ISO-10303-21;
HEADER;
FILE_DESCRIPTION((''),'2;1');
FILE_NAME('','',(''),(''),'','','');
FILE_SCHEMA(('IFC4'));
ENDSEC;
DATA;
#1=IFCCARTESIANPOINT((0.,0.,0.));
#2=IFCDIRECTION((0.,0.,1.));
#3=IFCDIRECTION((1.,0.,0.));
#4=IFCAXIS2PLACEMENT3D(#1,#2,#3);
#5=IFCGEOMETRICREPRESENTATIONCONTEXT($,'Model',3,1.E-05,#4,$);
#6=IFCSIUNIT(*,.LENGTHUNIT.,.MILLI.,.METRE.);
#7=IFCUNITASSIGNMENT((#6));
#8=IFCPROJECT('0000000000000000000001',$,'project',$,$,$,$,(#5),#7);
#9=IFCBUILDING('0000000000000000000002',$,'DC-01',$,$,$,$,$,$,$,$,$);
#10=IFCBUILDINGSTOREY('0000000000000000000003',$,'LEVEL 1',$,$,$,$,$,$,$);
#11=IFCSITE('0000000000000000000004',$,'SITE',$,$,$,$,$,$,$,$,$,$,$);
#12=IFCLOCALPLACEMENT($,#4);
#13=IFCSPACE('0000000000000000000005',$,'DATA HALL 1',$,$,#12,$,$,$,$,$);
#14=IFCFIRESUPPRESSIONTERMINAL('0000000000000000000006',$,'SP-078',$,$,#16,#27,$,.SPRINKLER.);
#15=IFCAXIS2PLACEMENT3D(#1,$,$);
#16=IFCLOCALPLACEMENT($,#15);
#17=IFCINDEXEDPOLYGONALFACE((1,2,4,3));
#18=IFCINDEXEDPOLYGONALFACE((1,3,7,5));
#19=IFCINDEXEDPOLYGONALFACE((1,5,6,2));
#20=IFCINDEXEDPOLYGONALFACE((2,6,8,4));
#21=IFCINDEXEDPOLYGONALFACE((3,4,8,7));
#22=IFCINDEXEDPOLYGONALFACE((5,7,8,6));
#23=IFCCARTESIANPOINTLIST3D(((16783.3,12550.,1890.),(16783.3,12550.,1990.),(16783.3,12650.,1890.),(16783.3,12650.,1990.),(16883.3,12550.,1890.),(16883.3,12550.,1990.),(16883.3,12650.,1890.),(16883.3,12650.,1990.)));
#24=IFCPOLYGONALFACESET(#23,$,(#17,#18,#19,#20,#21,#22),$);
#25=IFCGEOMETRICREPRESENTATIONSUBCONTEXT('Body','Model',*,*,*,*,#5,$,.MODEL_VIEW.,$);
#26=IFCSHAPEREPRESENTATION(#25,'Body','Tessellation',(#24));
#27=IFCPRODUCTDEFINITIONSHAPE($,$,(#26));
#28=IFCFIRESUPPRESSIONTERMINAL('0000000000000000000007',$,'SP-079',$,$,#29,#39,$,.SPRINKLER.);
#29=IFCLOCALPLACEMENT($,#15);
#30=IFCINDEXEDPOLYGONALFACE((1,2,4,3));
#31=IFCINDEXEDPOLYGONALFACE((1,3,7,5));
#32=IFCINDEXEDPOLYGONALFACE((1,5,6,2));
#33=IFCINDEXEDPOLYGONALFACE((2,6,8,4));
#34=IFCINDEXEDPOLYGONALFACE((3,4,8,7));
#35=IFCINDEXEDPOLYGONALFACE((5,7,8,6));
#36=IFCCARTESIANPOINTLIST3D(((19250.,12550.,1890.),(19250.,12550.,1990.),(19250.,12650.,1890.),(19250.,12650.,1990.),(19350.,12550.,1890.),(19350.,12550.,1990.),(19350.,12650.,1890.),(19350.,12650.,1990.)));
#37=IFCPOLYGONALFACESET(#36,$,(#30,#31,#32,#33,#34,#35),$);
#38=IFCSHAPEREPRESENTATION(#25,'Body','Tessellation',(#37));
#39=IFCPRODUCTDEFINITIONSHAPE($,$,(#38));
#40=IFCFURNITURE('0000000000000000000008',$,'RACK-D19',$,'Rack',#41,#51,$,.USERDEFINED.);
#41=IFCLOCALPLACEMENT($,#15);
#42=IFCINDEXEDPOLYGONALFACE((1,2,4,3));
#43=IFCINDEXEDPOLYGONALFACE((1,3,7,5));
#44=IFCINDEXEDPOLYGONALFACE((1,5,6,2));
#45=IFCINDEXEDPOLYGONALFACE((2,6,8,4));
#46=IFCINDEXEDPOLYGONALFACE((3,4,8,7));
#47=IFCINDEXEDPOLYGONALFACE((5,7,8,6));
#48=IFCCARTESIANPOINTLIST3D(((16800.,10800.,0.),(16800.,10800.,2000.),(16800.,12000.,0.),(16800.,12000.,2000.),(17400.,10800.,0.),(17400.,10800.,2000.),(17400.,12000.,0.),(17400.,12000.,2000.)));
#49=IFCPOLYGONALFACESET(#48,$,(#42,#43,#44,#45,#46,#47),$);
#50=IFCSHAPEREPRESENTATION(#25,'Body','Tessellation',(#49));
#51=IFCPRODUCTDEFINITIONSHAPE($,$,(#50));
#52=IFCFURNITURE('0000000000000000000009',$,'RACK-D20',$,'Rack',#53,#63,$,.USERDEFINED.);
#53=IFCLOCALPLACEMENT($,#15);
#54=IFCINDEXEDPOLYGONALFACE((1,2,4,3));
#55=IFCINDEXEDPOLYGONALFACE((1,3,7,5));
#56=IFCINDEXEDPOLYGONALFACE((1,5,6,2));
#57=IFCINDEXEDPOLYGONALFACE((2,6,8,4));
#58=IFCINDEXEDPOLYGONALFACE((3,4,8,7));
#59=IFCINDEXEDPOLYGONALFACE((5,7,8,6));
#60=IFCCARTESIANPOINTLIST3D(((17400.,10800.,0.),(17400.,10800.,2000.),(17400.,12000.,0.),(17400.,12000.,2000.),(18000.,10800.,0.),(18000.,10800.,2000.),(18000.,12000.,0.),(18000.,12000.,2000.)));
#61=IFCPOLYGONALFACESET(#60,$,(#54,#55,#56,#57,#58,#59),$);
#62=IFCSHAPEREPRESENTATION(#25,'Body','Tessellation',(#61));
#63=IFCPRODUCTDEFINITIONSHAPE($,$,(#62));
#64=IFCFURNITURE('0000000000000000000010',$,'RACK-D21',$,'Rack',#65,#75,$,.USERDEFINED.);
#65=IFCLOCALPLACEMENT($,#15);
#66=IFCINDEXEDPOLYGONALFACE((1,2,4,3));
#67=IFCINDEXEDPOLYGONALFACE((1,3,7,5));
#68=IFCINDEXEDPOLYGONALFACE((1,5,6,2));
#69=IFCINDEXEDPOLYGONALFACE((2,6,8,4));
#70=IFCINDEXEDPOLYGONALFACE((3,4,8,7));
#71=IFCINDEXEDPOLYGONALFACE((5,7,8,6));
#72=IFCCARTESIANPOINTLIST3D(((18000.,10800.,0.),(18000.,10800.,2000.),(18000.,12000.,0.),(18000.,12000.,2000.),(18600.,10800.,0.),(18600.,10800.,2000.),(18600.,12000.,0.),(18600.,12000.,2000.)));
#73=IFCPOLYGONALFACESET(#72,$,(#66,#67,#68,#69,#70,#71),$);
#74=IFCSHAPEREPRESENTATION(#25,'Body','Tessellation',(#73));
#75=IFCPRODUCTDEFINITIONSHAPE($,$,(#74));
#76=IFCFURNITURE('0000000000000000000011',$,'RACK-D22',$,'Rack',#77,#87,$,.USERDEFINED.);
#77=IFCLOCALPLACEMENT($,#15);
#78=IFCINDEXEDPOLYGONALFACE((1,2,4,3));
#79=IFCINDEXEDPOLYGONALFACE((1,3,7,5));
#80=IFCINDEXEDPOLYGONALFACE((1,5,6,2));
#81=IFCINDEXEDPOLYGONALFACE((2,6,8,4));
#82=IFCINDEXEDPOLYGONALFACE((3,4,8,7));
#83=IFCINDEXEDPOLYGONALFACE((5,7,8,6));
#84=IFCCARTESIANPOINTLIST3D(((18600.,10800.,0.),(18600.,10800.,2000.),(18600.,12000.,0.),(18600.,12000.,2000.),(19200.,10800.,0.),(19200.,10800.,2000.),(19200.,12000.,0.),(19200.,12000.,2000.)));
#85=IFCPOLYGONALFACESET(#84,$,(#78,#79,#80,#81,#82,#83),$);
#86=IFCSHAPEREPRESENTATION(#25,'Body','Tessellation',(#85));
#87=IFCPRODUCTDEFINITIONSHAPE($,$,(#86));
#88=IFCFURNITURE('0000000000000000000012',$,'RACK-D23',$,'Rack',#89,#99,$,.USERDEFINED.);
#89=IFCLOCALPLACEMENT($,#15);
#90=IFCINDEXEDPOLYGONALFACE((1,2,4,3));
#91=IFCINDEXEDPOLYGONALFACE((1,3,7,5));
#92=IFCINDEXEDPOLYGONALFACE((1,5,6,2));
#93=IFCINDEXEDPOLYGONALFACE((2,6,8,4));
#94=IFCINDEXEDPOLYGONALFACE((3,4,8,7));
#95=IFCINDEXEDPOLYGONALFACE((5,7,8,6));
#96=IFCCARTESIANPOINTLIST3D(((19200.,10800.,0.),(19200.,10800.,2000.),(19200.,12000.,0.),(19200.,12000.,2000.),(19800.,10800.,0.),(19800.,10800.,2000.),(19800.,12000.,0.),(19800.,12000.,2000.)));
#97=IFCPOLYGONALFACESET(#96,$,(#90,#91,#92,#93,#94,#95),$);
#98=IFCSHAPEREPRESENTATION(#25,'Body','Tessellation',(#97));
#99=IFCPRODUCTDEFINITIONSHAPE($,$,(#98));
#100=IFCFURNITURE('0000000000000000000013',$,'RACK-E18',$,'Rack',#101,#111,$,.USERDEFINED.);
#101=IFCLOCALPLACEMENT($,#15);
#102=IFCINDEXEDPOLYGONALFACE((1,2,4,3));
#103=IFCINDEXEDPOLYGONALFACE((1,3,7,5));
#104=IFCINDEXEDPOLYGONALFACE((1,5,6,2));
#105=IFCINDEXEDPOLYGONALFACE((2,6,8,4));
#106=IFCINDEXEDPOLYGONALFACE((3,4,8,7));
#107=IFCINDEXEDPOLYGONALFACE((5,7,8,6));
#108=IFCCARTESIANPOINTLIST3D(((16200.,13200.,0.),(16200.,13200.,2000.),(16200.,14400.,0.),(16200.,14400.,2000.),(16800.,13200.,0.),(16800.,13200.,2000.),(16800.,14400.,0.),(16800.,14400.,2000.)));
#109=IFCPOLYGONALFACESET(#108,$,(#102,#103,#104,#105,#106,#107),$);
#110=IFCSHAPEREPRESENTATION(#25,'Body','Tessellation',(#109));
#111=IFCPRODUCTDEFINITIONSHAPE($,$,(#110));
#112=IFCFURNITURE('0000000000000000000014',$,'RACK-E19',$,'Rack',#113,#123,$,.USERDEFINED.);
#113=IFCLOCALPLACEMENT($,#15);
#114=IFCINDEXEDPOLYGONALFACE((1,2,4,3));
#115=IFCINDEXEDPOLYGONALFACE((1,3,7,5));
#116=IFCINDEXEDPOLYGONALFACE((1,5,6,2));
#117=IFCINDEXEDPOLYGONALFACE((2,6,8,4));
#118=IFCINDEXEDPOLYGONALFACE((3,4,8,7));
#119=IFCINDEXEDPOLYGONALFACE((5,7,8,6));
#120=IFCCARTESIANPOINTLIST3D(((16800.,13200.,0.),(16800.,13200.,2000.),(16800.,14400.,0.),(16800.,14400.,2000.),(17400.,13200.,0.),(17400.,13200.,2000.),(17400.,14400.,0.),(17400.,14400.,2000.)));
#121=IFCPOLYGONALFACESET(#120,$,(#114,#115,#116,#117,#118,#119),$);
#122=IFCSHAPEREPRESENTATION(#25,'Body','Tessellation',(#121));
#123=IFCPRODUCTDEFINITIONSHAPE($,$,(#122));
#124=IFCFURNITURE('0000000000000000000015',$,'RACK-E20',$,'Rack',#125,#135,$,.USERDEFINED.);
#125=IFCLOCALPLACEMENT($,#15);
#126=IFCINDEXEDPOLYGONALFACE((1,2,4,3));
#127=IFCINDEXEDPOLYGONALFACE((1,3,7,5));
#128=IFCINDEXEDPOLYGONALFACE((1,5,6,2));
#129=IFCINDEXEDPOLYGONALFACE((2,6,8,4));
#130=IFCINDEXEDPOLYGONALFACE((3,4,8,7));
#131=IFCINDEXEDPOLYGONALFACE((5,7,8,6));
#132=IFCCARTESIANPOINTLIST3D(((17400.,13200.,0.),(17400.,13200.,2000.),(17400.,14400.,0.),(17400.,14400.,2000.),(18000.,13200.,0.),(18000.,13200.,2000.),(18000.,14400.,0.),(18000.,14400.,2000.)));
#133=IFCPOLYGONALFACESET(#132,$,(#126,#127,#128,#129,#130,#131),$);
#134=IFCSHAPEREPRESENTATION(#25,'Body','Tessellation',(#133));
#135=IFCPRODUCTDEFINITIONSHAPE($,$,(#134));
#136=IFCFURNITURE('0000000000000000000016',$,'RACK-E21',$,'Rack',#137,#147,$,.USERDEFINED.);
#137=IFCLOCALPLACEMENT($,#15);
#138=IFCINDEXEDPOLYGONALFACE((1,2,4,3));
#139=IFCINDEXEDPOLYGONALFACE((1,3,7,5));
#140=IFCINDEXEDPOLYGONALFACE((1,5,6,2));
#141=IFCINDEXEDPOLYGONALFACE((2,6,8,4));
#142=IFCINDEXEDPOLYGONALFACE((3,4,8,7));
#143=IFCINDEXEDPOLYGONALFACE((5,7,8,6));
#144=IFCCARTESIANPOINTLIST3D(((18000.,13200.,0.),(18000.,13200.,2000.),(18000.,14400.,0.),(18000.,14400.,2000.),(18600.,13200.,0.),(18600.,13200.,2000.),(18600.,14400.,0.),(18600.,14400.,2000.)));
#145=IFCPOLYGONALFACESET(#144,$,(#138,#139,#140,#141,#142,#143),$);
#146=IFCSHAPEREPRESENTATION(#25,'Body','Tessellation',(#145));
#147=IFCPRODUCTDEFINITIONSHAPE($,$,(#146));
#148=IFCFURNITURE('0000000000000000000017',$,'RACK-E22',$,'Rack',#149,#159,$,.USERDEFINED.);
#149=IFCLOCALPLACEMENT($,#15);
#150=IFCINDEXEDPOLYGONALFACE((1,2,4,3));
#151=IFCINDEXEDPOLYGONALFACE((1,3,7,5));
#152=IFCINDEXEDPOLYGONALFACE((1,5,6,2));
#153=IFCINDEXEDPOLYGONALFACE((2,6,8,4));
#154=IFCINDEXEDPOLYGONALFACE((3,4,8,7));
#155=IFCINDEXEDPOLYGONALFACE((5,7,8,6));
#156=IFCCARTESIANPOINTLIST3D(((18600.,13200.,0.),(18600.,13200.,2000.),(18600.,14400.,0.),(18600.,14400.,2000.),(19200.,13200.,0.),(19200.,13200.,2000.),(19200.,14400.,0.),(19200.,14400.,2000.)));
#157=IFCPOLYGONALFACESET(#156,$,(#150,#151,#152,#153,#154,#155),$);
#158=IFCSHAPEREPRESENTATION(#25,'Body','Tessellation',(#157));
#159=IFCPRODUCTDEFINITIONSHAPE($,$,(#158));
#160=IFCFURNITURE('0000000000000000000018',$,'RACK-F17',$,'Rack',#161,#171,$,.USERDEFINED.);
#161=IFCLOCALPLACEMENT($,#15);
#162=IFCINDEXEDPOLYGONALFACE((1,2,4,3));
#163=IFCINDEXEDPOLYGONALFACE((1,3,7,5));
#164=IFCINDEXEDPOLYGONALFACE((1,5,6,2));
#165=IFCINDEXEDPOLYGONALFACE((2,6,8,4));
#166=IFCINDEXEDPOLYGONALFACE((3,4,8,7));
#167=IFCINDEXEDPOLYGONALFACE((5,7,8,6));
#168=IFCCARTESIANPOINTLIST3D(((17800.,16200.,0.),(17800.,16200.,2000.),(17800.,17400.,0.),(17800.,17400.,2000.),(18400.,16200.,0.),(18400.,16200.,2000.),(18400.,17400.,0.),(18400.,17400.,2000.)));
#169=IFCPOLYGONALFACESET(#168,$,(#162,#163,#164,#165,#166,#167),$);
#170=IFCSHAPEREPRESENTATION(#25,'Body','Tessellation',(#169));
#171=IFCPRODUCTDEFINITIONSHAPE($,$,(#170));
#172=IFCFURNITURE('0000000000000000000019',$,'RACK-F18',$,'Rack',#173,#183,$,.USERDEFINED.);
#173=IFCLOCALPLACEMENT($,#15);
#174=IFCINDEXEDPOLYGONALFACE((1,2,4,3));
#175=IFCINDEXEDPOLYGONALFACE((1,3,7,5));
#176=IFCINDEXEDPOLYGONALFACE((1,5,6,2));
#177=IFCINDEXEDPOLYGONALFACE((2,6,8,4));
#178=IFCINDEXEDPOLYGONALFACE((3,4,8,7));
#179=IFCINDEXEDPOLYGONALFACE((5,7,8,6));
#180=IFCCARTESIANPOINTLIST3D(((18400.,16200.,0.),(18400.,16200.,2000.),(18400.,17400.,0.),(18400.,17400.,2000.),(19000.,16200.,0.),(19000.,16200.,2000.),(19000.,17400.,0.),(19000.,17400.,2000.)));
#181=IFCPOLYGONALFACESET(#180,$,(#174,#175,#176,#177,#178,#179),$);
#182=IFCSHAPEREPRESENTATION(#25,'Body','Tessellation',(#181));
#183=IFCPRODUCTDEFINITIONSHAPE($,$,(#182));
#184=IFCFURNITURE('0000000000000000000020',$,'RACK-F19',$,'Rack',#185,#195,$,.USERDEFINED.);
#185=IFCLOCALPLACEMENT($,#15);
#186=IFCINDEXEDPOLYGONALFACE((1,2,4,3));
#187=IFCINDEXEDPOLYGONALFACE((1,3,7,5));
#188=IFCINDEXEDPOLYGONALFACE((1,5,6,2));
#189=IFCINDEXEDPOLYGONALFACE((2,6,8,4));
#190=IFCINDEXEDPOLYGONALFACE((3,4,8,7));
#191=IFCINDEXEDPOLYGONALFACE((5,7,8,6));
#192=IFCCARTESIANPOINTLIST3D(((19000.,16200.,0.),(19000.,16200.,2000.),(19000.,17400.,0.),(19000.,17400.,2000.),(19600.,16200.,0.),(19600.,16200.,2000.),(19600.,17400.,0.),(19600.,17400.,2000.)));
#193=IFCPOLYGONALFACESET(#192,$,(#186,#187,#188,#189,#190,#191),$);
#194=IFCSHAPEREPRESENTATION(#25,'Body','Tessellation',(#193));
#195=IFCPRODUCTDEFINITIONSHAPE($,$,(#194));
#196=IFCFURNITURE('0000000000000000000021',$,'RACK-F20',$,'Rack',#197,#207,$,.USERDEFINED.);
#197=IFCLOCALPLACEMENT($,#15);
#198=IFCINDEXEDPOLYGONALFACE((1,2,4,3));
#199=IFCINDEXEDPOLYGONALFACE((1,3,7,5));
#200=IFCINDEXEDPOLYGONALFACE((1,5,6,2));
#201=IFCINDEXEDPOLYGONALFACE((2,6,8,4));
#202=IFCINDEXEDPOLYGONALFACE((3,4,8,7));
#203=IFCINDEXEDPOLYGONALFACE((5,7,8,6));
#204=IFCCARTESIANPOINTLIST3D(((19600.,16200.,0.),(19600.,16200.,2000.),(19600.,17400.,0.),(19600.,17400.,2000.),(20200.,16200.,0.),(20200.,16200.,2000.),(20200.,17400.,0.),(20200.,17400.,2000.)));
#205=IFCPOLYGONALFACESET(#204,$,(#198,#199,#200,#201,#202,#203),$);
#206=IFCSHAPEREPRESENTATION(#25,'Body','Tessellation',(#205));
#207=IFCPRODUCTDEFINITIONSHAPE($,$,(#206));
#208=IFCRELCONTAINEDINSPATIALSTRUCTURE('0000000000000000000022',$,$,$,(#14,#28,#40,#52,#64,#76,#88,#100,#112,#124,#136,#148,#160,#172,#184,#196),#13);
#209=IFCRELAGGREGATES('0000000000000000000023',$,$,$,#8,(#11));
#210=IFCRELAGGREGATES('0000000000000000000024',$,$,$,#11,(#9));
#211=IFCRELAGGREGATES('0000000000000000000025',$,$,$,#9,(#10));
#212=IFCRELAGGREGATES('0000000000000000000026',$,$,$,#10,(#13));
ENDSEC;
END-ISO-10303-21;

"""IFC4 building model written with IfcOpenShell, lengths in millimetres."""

from ifc_helpers import new_model, si_unit, frame, origin, origin_with_axes, place, context, subcontext, project, spatial, polyline, outline, extrude, element, save


model = new_model("IFC4")

# Units and contexts
model_context = context("Model", 3, precision=1e-05, world=origin_with_axes())
body_context = subcontext(model_context, "Body", "Model", "MODEL_VIEW")
ifc_project = project(units=[si_unit("LENGTHUNIT", "METRE", prefix="MILLI")], contexts=[model_context])

# Site, building, storey, space
site = spatial("IfcSite", under=ifc_project, Name="SITE")
building = spatial("IfcBuilding", under=site, Name="DC-01")
storey = spatial("IfcBuildingStorey", under=building, Name="LEVEL 1")
space_placement = place(None, origin_with_axes())
space = spatial("IfcSpace", under=storey, at=space_placement, Name="DATA HALL 1")

# Fire suppression terminals
for number, where, z_axis, x_axis, name in (
    (1, (16783.3, 12550.0, 1890.0), (0.0, 0.0, 1.0), (1.0, 0.0, 0.0), "SP-078"),
    (2, (19250.0, 12550.0, 1890.0), (0.0, 0.0, 1.0), (1.0, 0.0, 0.0), "SP-079"),
):
    element("IfcFireSuppressionTerminal", number, at=place(space_placement, frame(where, z_axis=z_axis, x_axis=x_axis)), inside=space, Name=name, PredefinedType="SPRINKLER", context=body_context, shape_type="SweptSolid", body=[
        extrude(outline(polyline([(0.0, 0.0), (100.0, 0.0), (100.0, 100.0), (0.0, 100.0), (0.0, 0.0)])), origin(), (0.0, 0.0, 1.0), 100.0),
    ])

# Furniture
for number, where, z_axis, x_axis, name in (
    (3, (16800.0, 10800.0, 0.0), (0.0, 0.0, 1.0), (1.0, 0.0, 0.0), "RACK-D19"),
    (4, (17400.0, 10800.0, 0.0), (0.0, 0.0, 1.0), (1.0, 0.0, 0.0), "RACK-D20"),
    (5, (18000.0, 10800.0, 0.0), (0.0, 0.0, 1.0), (1.0, 0.0, 0.0), "RACK-D21"),
    (6, (18600.0, 10800.0, 0.0), (0.0, 0.0, 1.0), (1.0, 0.0, 0.0), "RACK-D22"),
    (7, (19200.0, 10800.0, 0.0), (0.0, 0.0, 1.0), (1.0, 0.0, 0.0), "RACK-D23"),
    (8, (16800.0, 14400.0, 0.0), (0.0, 0.0, 1.0), (-1.0, 0.0, 0.0), "RACK-E18"),
    (9, (17400.0, 14400.0, 0.0), (0.0, 0.0, 1.0), (-1.0, 0.0, 0.0), "RACK-E19"),
    (10, (18000.0, 14400.0, 0.0), (0.0, 0.0, 1.0), (-1.0, 0.0, 0.0), "RACK-E20"),
    (11, (18600.0, 14400.0, 0.0), (0.0, 0.0, 1.0), (-1.0, 0.0, 0.0), "RACK-E21"),
    (12, (19200.0, 14400.0, 0.0), (0.0, 0.0, 1.0), (-1.0, 0.0, 0.0), "RACK-E22"),
    (13, (17800.0, 16200.0, 0.0), (0.0, 0.0, 1.0), (1.0, 0.0, 0.0), "RACK-F17"),
    (14, (18400.0, 16200.0, 0.0), (0.0, 0.0, 1.0), (1.0, 0.0, 0.0), "RACK-F18"),
    (15, (19000.0, 16200.0, 0.0), (0.0, 0.0, 1.0), (1.0, 0.0, 0.0), "RACK-F19"),
    (16, (19600.0, 16200.0, 0.0), (0.0, 0.0, 1.0), (1.0, 0.0, 0.0), "RACK-F20"),
):
    element("IfcFurniture", number, at=place(space_placement, frame(where, z_axis=z_axis, x_axis=x_axis)), inside=space, Name=name, ObjectType="Rack", PredefinedType="USERDEFINED", context=body_context, shape_type="SweptSolid", body=[
        extrude(outline(polyline([(0.0, 0.0), (600.0, 0.0), (600.0, 1200.0), (0.0, 1200.0), (0.0, 0.0)])), origin(), (0.0, 0.0, 1.0), 2000.0),
    ])

save(model, "model.ifc")
